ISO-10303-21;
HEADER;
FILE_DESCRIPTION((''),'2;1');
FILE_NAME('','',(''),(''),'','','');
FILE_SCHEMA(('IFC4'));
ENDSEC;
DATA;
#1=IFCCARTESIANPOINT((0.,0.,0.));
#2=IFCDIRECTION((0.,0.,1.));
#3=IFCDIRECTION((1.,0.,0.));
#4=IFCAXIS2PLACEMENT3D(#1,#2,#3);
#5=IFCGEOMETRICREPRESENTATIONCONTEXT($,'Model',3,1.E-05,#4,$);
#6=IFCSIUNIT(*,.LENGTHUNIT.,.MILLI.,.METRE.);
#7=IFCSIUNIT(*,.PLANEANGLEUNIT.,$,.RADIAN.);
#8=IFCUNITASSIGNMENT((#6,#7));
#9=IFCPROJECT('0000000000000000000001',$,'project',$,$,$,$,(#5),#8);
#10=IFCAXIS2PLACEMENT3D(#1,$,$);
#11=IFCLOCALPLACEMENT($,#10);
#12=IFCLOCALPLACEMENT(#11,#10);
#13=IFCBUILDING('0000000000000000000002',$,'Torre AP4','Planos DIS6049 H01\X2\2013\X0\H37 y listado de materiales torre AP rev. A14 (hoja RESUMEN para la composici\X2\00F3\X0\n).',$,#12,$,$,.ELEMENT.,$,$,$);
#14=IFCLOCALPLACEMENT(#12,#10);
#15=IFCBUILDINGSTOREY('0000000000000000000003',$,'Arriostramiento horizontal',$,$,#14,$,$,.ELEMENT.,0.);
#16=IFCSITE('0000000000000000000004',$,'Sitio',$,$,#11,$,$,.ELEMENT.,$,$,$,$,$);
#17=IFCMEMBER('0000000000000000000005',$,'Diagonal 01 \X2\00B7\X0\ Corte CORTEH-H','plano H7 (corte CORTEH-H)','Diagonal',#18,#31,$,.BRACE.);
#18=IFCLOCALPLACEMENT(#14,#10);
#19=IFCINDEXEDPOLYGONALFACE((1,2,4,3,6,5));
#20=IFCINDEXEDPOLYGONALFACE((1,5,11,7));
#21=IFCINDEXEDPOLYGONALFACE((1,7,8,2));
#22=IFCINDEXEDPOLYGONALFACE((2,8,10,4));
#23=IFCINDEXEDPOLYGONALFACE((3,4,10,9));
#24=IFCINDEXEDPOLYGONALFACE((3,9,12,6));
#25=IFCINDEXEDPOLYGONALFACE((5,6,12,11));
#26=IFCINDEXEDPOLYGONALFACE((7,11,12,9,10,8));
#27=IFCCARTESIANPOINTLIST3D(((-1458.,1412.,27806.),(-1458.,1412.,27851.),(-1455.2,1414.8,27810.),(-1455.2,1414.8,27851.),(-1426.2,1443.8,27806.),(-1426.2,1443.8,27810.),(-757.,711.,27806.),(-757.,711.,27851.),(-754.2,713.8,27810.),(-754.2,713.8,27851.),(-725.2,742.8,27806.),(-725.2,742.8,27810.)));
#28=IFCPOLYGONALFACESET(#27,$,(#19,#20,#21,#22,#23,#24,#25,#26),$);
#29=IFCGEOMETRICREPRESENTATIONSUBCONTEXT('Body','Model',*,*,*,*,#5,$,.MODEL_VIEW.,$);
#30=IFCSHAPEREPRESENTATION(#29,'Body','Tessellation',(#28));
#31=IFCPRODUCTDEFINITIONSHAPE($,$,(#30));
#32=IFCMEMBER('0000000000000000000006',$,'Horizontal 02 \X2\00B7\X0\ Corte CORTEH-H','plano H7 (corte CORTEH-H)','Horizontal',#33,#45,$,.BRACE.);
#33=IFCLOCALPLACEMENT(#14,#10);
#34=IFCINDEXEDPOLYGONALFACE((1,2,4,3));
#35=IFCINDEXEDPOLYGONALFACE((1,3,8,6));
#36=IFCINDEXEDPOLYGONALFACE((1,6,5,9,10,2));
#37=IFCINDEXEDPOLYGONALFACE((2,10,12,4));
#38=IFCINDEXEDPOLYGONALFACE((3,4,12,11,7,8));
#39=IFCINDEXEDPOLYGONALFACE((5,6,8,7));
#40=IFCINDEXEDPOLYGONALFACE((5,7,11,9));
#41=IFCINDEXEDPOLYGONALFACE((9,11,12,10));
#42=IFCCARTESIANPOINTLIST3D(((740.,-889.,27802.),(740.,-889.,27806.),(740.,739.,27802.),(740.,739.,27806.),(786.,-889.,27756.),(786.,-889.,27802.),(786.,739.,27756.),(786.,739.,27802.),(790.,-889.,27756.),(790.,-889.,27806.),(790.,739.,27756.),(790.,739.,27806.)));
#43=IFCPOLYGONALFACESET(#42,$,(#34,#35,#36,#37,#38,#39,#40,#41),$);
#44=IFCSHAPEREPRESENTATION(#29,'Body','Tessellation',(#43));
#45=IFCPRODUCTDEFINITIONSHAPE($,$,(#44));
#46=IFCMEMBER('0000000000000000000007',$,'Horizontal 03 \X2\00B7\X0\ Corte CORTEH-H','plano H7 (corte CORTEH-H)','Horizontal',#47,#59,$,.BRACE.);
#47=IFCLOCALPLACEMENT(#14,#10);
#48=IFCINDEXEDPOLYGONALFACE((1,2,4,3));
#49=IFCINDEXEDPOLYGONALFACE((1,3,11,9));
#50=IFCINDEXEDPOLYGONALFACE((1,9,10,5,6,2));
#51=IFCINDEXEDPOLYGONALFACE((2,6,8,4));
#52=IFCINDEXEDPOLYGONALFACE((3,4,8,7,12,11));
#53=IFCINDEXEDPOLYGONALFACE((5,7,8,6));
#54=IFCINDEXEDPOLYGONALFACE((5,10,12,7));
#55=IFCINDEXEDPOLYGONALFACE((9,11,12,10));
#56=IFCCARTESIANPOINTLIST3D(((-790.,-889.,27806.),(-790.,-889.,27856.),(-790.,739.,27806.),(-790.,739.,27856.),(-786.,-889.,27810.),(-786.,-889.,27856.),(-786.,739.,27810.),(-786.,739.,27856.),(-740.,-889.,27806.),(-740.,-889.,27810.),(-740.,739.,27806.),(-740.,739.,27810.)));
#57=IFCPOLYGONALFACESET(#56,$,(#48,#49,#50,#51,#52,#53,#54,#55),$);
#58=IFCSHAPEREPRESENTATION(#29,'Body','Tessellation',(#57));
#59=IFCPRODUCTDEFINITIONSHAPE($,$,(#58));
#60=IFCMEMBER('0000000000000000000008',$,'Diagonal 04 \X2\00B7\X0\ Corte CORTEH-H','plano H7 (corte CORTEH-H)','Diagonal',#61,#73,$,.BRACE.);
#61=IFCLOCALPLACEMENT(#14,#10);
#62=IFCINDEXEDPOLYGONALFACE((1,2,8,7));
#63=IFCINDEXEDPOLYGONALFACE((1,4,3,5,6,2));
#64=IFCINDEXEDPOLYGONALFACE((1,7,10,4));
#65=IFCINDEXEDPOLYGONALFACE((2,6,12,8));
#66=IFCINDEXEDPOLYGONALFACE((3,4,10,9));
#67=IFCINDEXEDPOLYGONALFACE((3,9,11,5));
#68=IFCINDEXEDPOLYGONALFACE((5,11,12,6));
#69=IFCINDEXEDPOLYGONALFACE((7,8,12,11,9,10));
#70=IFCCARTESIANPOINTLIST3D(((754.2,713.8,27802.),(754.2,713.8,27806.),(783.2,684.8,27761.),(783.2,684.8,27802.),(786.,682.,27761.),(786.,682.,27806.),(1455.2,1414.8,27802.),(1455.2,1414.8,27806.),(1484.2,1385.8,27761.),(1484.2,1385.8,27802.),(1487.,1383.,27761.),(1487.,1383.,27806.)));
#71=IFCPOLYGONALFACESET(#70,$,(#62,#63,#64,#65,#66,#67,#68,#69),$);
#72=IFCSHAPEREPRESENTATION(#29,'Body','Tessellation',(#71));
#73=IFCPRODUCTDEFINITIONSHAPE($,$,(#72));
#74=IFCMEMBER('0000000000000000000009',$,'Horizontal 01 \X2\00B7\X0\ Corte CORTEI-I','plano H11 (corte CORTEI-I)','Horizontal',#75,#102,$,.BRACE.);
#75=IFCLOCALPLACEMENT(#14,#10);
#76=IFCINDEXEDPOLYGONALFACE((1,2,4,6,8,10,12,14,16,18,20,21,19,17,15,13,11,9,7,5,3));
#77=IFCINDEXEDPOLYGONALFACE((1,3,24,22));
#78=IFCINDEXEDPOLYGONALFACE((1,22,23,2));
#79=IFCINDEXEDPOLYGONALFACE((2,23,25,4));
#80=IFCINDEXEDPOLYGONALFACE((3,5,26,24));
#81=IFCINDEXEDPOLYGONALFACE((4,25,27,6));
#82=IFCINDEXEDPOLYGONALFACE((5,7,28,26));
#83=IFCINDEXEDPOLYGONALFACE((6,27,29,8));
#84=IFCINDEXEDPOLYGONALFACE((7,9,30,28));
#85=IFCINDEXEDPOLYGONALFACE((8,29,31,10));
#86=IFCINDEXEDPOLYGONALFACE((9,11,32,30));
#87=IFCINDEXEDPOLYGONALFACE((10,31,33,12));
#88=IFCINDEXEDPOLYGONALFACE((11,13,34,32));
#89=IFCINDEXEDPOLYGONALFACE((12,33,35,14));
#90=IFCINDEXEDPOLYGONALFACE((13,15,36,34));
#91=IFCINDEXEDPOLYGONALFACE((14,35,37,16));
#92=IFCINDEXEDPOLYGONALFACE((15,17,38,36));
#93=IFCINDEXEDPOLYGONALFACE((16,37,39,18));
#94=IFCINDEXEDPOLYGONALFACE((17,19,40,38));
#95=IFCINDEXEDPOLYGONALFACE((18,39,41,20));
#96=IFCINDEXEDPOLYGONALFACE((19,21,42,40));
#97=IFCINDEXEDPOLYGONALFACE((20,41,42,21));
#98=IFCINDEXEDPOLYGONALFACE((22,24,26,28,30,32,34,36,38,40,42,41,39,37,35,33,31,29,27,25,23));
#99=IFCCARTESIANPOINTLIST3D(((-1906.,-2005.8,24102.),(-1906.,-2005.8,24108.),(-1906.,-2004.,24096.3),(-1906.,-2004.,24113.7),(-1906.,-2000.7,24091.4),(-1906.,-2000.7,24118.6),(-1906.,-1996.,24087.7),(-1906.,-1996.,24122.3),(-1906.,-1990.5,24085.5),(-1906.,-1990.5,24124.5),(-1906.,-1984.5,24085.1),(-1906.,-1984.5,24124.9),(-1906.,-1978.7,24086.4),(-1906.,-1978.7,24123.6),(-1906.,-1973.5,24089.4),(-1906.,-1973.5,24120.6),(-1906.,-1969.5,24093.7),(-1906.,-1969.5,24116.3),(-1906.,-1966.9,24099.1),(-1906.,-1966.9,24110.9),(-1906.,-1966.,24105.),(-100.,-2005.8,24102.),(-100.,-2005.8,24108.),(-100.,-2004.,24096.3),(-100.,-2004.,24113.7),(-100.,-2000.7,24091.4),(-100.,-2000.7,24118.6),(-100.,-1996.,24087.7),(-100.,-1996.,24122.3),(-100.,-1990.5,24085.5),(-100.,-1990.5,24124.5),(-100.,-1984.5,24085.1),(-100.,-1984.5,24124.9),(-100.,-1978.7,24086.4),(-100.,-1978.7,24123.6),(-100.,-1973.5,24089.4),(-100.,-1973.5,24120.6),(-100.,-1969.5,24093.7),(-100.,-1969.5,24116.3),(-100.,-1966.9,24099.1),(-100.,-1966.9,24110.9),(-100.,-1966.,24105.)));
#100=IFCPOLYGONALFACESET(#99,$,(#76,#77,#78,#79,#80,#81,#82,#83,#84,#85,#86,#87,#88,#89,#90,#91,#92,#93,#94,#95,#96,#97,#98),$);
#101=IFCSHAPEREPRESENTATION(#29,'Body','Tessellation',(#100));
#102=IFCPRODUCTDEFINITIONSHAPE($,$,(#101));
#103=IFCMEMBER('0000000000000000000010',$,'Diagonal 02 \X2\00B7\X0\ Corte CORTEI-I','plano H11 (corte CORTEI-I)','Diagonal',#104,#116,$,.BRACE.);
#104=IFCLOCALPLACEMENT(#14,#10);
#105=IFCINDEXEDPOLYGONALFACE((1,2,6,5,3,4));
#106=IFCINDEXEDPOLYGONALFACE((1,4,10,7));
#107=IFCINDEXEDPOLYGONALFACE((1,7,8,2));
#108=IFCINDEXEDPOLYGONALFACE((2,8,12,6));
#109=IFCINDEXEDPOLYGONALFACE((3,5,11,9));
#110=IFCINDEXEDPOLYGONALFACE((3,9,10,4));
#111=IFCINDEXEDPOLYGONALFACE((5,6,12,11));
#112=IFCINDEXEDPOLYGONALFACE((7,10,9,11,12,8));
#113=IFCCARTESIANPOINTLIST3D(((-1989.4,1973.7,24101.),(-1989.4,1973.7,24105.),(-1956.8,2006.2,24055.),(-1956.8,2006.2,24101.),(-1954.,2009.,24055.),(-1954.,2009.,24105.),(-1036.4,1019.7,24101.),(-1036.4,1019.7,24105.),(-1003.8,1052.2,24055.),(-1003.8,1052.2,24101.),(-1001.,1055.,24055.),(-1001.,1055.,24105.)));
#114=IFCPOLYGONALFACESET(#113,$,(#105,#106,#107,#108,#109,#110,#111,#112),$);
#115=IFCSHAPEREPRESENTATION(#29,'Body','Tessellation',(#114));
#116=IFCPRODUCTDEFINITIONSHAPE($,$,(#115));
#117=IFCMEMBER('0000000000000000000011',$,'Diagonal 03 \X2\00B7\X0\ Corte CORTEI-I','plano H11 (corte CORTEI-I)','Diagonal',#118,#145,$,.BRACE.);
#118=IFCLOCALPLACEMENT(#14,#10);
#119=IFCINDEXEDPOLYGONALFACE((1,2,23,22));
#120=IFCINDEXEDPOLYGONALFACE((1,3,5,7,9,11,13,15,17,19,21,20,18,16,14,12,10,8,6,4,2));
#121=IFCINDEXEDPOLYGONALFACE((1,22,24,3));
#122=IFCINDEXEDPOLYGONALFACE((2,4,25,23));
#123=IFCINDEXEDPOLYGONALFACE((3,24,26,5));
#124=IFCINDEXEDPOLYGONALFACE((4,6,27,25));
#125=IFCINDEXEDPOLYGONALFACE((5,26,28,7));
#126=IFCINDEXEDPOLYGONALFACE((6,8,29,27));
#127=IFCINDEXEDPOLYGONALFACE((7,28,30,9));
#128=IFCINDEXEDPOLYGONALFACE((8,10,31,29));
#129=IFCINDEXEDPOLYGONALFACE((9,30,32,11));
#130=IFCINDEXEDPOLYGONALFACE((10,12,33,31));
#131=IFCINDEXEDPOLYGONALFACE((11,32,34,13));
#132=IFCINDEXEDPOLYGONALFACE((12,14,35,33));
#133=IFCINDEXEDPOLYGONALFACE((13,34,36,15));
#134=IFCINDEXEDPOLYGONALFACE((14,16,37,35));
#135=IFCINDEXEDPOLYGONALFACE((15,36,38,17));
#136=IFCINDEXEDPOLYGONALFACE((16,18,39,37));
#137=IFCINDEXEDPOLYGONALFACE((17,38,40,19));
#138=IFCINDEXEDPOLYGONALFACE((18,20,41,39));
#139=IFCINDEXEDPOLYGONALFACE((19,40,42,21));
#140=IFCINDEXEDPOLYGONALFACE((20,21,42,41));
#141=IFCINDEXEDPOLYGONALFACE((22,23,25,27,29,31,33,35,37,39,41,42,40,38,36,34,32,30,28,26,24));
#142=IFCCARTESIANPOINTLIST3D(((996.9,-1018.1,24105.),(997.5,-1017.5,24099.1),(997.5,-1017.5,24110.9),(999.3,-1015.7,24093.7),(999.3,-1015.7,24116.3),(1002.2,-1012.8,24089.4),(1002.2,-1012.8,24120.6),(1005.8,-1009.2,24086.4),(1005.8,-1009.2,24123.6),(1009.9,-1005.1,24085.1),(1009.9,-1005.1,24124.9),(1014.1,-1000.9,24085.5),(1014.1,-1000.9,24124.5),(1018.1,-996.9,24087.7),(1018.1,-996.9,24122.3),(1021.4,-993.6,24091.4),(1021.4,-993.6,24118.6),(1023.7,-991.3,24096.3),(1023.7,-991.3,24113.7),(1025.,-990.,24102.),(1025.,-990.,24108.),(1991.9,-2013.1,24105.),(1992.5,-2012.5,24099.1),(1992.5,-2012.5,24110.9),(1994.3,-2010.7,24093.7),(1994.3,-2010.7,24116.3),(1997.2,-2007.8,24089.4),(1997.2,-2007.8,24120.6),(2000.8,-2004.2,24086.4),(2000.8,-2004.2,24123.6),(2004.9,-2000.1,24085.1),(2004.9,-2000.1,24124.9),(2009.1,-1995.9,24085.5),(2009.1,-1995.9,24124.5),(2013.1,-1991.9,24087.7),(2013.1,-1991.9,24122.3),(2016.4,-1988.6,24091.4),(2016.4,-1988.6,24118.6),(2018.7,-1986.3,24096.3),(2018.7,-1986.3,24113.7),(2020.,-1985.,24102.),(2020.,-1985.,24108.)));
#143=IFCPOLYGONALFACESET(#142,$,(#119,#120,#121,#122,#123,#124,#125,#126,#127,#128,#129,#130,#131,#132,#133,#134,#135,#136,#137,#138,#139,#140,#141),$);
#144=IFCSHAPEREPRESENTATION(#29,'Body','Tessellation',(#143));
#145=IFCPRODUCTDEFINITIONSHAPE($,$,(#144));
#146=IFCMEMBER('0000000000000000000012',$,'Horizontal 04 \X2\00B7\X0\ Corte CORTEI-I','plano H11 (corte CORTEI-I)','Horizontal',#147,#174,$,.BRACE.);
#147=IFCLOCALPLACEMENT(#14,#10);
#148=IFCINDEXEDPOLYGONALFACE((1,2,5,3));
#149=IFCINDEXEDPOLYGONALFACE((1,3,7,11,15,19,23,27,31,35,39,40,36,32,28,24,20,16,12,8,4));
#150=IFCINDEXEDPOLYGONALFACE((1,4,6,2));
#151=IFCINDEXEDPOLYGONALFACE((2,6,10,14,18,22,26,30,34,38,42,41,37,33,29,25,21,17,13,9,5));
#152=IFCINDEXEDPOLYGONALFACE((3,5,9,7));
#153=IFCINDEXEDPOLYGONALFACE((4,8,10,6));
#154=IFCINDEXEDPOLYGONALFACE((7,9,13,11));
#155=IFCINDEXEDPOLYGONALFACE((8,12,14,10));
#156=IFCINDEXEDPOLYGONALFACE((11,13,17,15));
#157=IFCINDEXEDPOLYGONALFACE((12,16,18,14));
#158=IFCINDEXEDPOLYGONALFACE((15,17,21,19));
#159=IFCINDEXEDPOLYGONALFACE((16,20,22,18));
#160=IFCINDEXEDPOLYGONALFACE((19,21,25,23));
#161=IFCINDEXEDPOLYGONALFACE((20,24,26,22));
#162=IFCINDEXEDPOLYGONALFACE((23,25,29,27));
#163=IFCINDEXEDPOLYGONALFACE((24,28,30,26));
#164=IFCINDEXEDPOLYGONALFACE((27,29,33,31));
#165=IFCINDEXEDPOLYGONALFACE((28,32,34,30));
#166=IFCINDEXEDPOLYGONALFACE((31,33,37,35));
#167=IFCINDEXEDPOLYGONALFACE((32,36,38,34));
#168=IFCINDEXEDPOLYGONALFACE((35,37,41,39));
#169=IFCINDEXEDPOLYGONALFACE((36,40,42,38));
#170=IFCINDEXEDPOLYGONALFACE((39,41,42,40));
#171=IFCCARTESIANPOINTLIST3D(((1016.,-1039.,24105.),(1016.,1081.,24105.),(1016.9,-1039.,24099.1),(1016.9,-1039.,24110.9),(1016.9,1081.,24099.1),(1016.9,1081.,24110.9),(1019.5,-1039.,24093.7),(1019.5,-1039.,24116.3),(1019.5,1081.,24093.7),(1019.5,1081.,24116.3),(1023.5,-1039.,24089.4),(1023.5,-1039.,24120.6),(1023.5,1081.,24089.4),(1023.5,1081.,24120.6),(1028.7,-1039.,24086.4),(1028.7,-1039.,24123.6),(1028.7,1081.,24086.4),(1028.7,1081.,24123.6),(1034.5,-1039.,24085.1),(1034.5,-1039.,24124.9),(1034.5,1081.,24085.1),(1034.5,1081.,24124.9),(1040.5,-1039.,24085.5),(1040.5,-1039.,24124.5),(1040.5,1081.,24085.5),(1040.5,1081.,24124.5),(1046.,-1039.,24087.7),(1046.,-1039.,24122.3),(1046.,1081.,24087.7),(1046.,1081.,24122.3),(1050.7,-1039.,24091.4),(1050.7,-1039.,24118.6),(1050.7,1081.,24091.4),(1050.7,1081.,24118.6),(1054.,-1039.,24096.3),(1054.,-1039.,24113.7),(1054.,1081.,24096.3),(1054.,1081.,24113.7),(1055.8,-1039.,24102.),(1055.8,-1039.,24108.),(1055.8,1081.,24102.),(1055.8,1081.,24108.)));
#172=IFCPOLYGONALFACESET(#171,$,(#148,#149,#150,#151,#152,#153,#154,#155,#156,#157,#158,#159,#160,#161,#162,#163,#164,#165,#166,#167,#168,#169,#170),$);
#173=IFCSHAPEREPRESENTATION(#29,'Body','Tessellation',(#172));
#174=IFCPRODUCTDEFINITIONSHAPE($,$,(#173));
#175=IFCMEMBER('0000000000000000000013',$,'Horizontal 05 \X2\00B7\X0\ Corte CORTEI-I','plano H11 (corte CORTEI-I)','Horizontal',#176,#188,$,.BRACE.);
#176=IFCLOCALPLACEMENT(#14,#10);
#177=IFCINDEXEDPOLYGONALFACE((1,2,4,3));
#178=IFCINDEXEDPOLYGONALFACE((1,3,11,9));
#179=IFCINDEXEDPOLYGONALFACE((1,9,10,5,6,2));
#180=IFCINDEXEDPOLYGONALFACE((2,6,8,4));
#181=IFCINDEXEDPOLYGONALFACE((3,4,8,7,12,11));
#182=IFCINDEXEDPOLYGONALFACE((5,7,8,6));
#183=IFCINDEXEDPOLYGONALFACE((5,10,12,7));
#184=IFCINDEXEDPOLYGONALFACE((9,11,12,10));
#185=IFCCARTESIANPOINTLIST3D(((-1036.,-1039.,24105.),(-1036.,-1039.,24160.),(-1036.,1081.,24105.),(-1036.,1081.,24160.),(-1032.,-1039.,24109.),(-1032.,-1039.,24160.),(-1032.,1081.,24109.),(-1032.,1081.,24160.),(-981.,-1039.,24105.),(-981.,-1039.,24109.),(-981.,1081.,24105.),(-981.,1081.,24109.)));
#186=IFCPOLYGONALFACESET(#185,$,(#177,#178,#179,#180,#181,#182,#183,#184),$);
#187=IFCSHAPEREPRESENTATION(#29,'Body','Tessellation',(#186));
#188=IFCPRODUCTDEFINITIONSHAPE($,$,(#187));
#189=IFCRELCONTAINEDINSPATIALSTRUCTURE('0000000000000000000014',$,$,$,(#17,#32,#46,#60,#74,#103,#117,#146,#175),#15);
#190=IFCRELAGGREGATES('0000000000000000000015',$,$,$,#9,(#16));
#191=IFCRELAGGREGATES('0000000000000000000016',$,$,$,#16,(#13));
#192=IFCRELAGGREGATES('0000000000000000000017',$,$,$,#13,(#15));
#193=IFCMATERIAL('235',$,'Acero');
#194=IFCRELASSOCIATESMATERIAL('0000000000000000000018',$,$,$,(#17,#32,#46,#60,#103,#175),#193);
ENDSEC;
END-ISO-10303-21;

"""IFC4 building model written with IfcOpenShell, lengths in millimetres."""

from ifc_helpers import new_model, si_unit, frame, frame_2d, origin, origin_with_axes, place, context, subcontext, project, spatial, circle, l_section, extrude, material, element, save


model = new_model("IFC4")

# Units and contexts
model_context = context("Model", 3, precision=1e-05, world=origin_with_axes())
body_context = subcontext(model_context, "Body", "Model", "MODEL_VIEW")
ifc_project = project(units=[si_unit("LENGTHUNIT", "METRE", prefix="MILLI"), si_unit("PLANEANGLEUNIT", "RADIAN")], contexts=[model_context])

# Site, building, storey
site_placement = place(None, origin())
site = spatial("IfcSite", under=ifc_project, at=site_placement, Name="Sitio", CompositionType="ELEMENT")
building_placement = place(site_placement, origin())
building = spatial("IfcBuilding", under=site, at=building_placement, Name="Torre AP4", Description="Planos DIS6049 H01–H37 y listado de materiales torre AP rev. A14 (hoja RESUMEN para la composición).", CompositionType="ELEMENT")
storey_placement = place(building_placement, origin())
storey = spatial("IfcBuildingStorey", under=building, at=storey_placement, Name="Arriostramiento horizontal", CompositionType="ELEMENT", Elevation=0.0)

# Members
ifc_material = material(Name="235", Category="Acero")
member_1_placement = place(storey_placement, frame((-1458.0, 1412.0, 27806.0), z_axis=(0.707107, -0.707107, 0.0), x_axis=(0.707107, 0.707107, 0.0)))
element("IfcMember", 1, at=member_1_placement, inside=storey, material=ifc_material, Name="Diagonal 01 · Corte CORTEH-H", Description="plano H7 (corte CORTEH-H)", ObjectType="Diagonal", PredefinedType="BRACE", context=body_context, shape_type="SweptSolid", body=[
    extrude(l_section(Depth=45.0, Width=45.0, Thickness=4.0, at=frame_2d((22.5, 22.5))), None, (0.0, 0.0, 1.0), 991.4),
])
for number, where, z_axis, x_axis, name in (
    (2, (790.0, 739.0, 27806.0), (0.0, -1.0, 0.0), (-1.0, 0.0, 0.0), "Horizontal 02 · Corte CORTEH-H"),
    (3, (-790.0, 739.0, 27806.0), (0.0, -1.0, 0.0), (1.0, 0.0, 0.0), "Horizontal 03 · Corte CORTEH-H"),
):
    element("IfcMember", number, at=place(storey_placement, frame(where, z_axis=z_axis, x_axis=x_axis)), inside=storey, material=ifc_material, Name=name, Description="plano H7 (corte CORTEH-H)", ObjectType="Horizontal", PredefinedType="BRACE", context=body_context, shape_type="SweptSolid", body=[
        extrude(l_section(Depth=50.0, Width=50.0, Thickness=4.0, at=frame_2d((25.0, 25.0))), None, (0.0, 0.0, 1.0), 1628.0),
    ])
member_2_placement = place(storey_placement, frame((1487.0, 1383.0, 27806.0), z_axis=(-0.707107, -0.707107, 0.0), x_axis=(-0.707107, 0.707107, 0.0)))
element("IfcMember", 4, at=member_2_placement, inside=storey, material=ifc_material, Name="Diagonal 04 · Corte CORTEH-H", Description="plano H7 (corte CORTEH-H)", ObjectType="Diagonal", PredefinedType="BRACE", context=body_context, shape_type="SweptSolid", body=[
    extrude(l_section(Depth=45.0, Width=45.0, Thickness=4.0, at=frame_2d((22.5, 22.5))), None, (0.0, 0.0, 1.0), 991.4),
])
member_3_placement = place(storey_placement, frame((-1906.0, -1986.0, 24105.0), z_axis=(1.0, 0.0, 0.0), x_axis=(0.0, 1.0, 0.0)))
element("IfcMember", 5, at=member_3_placement, inside=storey, Name="Horizontal 01 · Corte CORTEI-I", Description="plano H11 (corte CORTEI-I)", ObjectType="Horizontal", PredefinedType="BRACE", context=body_context, shape_type="SweptSolid", body=[
    extrude(circle(Radius=20.0), None, (0.0, 0.0, 1.0), 1806.0),
])
member_4_placement = place(storey_placement, frame((-1954.0, 2009.0, 24105.0), z_axis=(0.706736, -0.707477, 0.0), x_axis=(-0.707477, -0.706736, 0.0)))
element("IfcMember", 6, at=member_4_placement, inside=storey, material=ifc_material, Name="Diagonal 02 · Corte CORTEI-I", Description="plano H11 (corte CORTEI-I)", ObjectType="Diagonal", PredefinedType="BRACE", context=body_context, shape_type="SweptSolid", body=[
    extrude(l_section(Depth=50.0, Width=50.0, Thickness=4.0, at=frame_2d((25.0, 25.0))), None, (0.0, 0.0, 1.0), 1348.5),
])
member_5_placement = place(storey_placement, frame((1011.0, -1004.0, 24105.0), z_axis=(0.707107, -0.707107, 0.0), x_axis=(-0.707107, -0.707107, 0.0)))
element("IfcMember", 7, at=member_5_placement, inside=storey, Name="Diagonal 03 · Corte CORTEI-I", Description="plano H11 (corte CORTEI-I)", ObjectType="Diagonal", PredefinedType="BRACE", context=body_context, shape_type="SweptSolid", body=[
    extrude(circle(Radius=20.0), None, (0.0, 0.0, 1.0), 1407.1),
])
member_6_placement = place(storey_placement, frame((1036.0, 1081.0, 24105.0), z_axis=(0.0, -1.0, 0.0), x_axis=(-1.0, 0.0, 0.0)))
element("IfcMember", 8, at=member_6_placement, inside=storey, Name="Horizontal 04 · Corte CORTEI-I", Description="plano H11 (corte CORTEI-I)", ObjectType="Horizontal", PredefinedType="BRACE", context=body_context, shape_type="SweptSolid", body=[
    extrude(circle(Radius=20.0), None, (0.0, 0.0, 1.0), 2120.0),
])
member_7_placement = place(storey_placement, frame((-1036.0, 1081.0, 24105.0), z_axis=(0.0, -1.0, 0.0), x_axis=(1.0, 0.0, 0.0)))
element("IfcMember", 9, at=member_7_placement, inside=storey, material=ifc_material, Name="Horizontal 05 · Corte CORTEI-I", Description="plano H11 (corte CORTEI-I)", ObjectType="Horizontal", PredefinedType="BRACE", context=body_context, shape_type="SweptSolid", body=[
    extrude(l_section(Depth=55.0, Width=55.0, Thickness=4.0, at=frame_2d((27.5, 27.5))), None, (0.0, 0.0, 1.0), 2120.0),
])

save(model, "model.ifc")
